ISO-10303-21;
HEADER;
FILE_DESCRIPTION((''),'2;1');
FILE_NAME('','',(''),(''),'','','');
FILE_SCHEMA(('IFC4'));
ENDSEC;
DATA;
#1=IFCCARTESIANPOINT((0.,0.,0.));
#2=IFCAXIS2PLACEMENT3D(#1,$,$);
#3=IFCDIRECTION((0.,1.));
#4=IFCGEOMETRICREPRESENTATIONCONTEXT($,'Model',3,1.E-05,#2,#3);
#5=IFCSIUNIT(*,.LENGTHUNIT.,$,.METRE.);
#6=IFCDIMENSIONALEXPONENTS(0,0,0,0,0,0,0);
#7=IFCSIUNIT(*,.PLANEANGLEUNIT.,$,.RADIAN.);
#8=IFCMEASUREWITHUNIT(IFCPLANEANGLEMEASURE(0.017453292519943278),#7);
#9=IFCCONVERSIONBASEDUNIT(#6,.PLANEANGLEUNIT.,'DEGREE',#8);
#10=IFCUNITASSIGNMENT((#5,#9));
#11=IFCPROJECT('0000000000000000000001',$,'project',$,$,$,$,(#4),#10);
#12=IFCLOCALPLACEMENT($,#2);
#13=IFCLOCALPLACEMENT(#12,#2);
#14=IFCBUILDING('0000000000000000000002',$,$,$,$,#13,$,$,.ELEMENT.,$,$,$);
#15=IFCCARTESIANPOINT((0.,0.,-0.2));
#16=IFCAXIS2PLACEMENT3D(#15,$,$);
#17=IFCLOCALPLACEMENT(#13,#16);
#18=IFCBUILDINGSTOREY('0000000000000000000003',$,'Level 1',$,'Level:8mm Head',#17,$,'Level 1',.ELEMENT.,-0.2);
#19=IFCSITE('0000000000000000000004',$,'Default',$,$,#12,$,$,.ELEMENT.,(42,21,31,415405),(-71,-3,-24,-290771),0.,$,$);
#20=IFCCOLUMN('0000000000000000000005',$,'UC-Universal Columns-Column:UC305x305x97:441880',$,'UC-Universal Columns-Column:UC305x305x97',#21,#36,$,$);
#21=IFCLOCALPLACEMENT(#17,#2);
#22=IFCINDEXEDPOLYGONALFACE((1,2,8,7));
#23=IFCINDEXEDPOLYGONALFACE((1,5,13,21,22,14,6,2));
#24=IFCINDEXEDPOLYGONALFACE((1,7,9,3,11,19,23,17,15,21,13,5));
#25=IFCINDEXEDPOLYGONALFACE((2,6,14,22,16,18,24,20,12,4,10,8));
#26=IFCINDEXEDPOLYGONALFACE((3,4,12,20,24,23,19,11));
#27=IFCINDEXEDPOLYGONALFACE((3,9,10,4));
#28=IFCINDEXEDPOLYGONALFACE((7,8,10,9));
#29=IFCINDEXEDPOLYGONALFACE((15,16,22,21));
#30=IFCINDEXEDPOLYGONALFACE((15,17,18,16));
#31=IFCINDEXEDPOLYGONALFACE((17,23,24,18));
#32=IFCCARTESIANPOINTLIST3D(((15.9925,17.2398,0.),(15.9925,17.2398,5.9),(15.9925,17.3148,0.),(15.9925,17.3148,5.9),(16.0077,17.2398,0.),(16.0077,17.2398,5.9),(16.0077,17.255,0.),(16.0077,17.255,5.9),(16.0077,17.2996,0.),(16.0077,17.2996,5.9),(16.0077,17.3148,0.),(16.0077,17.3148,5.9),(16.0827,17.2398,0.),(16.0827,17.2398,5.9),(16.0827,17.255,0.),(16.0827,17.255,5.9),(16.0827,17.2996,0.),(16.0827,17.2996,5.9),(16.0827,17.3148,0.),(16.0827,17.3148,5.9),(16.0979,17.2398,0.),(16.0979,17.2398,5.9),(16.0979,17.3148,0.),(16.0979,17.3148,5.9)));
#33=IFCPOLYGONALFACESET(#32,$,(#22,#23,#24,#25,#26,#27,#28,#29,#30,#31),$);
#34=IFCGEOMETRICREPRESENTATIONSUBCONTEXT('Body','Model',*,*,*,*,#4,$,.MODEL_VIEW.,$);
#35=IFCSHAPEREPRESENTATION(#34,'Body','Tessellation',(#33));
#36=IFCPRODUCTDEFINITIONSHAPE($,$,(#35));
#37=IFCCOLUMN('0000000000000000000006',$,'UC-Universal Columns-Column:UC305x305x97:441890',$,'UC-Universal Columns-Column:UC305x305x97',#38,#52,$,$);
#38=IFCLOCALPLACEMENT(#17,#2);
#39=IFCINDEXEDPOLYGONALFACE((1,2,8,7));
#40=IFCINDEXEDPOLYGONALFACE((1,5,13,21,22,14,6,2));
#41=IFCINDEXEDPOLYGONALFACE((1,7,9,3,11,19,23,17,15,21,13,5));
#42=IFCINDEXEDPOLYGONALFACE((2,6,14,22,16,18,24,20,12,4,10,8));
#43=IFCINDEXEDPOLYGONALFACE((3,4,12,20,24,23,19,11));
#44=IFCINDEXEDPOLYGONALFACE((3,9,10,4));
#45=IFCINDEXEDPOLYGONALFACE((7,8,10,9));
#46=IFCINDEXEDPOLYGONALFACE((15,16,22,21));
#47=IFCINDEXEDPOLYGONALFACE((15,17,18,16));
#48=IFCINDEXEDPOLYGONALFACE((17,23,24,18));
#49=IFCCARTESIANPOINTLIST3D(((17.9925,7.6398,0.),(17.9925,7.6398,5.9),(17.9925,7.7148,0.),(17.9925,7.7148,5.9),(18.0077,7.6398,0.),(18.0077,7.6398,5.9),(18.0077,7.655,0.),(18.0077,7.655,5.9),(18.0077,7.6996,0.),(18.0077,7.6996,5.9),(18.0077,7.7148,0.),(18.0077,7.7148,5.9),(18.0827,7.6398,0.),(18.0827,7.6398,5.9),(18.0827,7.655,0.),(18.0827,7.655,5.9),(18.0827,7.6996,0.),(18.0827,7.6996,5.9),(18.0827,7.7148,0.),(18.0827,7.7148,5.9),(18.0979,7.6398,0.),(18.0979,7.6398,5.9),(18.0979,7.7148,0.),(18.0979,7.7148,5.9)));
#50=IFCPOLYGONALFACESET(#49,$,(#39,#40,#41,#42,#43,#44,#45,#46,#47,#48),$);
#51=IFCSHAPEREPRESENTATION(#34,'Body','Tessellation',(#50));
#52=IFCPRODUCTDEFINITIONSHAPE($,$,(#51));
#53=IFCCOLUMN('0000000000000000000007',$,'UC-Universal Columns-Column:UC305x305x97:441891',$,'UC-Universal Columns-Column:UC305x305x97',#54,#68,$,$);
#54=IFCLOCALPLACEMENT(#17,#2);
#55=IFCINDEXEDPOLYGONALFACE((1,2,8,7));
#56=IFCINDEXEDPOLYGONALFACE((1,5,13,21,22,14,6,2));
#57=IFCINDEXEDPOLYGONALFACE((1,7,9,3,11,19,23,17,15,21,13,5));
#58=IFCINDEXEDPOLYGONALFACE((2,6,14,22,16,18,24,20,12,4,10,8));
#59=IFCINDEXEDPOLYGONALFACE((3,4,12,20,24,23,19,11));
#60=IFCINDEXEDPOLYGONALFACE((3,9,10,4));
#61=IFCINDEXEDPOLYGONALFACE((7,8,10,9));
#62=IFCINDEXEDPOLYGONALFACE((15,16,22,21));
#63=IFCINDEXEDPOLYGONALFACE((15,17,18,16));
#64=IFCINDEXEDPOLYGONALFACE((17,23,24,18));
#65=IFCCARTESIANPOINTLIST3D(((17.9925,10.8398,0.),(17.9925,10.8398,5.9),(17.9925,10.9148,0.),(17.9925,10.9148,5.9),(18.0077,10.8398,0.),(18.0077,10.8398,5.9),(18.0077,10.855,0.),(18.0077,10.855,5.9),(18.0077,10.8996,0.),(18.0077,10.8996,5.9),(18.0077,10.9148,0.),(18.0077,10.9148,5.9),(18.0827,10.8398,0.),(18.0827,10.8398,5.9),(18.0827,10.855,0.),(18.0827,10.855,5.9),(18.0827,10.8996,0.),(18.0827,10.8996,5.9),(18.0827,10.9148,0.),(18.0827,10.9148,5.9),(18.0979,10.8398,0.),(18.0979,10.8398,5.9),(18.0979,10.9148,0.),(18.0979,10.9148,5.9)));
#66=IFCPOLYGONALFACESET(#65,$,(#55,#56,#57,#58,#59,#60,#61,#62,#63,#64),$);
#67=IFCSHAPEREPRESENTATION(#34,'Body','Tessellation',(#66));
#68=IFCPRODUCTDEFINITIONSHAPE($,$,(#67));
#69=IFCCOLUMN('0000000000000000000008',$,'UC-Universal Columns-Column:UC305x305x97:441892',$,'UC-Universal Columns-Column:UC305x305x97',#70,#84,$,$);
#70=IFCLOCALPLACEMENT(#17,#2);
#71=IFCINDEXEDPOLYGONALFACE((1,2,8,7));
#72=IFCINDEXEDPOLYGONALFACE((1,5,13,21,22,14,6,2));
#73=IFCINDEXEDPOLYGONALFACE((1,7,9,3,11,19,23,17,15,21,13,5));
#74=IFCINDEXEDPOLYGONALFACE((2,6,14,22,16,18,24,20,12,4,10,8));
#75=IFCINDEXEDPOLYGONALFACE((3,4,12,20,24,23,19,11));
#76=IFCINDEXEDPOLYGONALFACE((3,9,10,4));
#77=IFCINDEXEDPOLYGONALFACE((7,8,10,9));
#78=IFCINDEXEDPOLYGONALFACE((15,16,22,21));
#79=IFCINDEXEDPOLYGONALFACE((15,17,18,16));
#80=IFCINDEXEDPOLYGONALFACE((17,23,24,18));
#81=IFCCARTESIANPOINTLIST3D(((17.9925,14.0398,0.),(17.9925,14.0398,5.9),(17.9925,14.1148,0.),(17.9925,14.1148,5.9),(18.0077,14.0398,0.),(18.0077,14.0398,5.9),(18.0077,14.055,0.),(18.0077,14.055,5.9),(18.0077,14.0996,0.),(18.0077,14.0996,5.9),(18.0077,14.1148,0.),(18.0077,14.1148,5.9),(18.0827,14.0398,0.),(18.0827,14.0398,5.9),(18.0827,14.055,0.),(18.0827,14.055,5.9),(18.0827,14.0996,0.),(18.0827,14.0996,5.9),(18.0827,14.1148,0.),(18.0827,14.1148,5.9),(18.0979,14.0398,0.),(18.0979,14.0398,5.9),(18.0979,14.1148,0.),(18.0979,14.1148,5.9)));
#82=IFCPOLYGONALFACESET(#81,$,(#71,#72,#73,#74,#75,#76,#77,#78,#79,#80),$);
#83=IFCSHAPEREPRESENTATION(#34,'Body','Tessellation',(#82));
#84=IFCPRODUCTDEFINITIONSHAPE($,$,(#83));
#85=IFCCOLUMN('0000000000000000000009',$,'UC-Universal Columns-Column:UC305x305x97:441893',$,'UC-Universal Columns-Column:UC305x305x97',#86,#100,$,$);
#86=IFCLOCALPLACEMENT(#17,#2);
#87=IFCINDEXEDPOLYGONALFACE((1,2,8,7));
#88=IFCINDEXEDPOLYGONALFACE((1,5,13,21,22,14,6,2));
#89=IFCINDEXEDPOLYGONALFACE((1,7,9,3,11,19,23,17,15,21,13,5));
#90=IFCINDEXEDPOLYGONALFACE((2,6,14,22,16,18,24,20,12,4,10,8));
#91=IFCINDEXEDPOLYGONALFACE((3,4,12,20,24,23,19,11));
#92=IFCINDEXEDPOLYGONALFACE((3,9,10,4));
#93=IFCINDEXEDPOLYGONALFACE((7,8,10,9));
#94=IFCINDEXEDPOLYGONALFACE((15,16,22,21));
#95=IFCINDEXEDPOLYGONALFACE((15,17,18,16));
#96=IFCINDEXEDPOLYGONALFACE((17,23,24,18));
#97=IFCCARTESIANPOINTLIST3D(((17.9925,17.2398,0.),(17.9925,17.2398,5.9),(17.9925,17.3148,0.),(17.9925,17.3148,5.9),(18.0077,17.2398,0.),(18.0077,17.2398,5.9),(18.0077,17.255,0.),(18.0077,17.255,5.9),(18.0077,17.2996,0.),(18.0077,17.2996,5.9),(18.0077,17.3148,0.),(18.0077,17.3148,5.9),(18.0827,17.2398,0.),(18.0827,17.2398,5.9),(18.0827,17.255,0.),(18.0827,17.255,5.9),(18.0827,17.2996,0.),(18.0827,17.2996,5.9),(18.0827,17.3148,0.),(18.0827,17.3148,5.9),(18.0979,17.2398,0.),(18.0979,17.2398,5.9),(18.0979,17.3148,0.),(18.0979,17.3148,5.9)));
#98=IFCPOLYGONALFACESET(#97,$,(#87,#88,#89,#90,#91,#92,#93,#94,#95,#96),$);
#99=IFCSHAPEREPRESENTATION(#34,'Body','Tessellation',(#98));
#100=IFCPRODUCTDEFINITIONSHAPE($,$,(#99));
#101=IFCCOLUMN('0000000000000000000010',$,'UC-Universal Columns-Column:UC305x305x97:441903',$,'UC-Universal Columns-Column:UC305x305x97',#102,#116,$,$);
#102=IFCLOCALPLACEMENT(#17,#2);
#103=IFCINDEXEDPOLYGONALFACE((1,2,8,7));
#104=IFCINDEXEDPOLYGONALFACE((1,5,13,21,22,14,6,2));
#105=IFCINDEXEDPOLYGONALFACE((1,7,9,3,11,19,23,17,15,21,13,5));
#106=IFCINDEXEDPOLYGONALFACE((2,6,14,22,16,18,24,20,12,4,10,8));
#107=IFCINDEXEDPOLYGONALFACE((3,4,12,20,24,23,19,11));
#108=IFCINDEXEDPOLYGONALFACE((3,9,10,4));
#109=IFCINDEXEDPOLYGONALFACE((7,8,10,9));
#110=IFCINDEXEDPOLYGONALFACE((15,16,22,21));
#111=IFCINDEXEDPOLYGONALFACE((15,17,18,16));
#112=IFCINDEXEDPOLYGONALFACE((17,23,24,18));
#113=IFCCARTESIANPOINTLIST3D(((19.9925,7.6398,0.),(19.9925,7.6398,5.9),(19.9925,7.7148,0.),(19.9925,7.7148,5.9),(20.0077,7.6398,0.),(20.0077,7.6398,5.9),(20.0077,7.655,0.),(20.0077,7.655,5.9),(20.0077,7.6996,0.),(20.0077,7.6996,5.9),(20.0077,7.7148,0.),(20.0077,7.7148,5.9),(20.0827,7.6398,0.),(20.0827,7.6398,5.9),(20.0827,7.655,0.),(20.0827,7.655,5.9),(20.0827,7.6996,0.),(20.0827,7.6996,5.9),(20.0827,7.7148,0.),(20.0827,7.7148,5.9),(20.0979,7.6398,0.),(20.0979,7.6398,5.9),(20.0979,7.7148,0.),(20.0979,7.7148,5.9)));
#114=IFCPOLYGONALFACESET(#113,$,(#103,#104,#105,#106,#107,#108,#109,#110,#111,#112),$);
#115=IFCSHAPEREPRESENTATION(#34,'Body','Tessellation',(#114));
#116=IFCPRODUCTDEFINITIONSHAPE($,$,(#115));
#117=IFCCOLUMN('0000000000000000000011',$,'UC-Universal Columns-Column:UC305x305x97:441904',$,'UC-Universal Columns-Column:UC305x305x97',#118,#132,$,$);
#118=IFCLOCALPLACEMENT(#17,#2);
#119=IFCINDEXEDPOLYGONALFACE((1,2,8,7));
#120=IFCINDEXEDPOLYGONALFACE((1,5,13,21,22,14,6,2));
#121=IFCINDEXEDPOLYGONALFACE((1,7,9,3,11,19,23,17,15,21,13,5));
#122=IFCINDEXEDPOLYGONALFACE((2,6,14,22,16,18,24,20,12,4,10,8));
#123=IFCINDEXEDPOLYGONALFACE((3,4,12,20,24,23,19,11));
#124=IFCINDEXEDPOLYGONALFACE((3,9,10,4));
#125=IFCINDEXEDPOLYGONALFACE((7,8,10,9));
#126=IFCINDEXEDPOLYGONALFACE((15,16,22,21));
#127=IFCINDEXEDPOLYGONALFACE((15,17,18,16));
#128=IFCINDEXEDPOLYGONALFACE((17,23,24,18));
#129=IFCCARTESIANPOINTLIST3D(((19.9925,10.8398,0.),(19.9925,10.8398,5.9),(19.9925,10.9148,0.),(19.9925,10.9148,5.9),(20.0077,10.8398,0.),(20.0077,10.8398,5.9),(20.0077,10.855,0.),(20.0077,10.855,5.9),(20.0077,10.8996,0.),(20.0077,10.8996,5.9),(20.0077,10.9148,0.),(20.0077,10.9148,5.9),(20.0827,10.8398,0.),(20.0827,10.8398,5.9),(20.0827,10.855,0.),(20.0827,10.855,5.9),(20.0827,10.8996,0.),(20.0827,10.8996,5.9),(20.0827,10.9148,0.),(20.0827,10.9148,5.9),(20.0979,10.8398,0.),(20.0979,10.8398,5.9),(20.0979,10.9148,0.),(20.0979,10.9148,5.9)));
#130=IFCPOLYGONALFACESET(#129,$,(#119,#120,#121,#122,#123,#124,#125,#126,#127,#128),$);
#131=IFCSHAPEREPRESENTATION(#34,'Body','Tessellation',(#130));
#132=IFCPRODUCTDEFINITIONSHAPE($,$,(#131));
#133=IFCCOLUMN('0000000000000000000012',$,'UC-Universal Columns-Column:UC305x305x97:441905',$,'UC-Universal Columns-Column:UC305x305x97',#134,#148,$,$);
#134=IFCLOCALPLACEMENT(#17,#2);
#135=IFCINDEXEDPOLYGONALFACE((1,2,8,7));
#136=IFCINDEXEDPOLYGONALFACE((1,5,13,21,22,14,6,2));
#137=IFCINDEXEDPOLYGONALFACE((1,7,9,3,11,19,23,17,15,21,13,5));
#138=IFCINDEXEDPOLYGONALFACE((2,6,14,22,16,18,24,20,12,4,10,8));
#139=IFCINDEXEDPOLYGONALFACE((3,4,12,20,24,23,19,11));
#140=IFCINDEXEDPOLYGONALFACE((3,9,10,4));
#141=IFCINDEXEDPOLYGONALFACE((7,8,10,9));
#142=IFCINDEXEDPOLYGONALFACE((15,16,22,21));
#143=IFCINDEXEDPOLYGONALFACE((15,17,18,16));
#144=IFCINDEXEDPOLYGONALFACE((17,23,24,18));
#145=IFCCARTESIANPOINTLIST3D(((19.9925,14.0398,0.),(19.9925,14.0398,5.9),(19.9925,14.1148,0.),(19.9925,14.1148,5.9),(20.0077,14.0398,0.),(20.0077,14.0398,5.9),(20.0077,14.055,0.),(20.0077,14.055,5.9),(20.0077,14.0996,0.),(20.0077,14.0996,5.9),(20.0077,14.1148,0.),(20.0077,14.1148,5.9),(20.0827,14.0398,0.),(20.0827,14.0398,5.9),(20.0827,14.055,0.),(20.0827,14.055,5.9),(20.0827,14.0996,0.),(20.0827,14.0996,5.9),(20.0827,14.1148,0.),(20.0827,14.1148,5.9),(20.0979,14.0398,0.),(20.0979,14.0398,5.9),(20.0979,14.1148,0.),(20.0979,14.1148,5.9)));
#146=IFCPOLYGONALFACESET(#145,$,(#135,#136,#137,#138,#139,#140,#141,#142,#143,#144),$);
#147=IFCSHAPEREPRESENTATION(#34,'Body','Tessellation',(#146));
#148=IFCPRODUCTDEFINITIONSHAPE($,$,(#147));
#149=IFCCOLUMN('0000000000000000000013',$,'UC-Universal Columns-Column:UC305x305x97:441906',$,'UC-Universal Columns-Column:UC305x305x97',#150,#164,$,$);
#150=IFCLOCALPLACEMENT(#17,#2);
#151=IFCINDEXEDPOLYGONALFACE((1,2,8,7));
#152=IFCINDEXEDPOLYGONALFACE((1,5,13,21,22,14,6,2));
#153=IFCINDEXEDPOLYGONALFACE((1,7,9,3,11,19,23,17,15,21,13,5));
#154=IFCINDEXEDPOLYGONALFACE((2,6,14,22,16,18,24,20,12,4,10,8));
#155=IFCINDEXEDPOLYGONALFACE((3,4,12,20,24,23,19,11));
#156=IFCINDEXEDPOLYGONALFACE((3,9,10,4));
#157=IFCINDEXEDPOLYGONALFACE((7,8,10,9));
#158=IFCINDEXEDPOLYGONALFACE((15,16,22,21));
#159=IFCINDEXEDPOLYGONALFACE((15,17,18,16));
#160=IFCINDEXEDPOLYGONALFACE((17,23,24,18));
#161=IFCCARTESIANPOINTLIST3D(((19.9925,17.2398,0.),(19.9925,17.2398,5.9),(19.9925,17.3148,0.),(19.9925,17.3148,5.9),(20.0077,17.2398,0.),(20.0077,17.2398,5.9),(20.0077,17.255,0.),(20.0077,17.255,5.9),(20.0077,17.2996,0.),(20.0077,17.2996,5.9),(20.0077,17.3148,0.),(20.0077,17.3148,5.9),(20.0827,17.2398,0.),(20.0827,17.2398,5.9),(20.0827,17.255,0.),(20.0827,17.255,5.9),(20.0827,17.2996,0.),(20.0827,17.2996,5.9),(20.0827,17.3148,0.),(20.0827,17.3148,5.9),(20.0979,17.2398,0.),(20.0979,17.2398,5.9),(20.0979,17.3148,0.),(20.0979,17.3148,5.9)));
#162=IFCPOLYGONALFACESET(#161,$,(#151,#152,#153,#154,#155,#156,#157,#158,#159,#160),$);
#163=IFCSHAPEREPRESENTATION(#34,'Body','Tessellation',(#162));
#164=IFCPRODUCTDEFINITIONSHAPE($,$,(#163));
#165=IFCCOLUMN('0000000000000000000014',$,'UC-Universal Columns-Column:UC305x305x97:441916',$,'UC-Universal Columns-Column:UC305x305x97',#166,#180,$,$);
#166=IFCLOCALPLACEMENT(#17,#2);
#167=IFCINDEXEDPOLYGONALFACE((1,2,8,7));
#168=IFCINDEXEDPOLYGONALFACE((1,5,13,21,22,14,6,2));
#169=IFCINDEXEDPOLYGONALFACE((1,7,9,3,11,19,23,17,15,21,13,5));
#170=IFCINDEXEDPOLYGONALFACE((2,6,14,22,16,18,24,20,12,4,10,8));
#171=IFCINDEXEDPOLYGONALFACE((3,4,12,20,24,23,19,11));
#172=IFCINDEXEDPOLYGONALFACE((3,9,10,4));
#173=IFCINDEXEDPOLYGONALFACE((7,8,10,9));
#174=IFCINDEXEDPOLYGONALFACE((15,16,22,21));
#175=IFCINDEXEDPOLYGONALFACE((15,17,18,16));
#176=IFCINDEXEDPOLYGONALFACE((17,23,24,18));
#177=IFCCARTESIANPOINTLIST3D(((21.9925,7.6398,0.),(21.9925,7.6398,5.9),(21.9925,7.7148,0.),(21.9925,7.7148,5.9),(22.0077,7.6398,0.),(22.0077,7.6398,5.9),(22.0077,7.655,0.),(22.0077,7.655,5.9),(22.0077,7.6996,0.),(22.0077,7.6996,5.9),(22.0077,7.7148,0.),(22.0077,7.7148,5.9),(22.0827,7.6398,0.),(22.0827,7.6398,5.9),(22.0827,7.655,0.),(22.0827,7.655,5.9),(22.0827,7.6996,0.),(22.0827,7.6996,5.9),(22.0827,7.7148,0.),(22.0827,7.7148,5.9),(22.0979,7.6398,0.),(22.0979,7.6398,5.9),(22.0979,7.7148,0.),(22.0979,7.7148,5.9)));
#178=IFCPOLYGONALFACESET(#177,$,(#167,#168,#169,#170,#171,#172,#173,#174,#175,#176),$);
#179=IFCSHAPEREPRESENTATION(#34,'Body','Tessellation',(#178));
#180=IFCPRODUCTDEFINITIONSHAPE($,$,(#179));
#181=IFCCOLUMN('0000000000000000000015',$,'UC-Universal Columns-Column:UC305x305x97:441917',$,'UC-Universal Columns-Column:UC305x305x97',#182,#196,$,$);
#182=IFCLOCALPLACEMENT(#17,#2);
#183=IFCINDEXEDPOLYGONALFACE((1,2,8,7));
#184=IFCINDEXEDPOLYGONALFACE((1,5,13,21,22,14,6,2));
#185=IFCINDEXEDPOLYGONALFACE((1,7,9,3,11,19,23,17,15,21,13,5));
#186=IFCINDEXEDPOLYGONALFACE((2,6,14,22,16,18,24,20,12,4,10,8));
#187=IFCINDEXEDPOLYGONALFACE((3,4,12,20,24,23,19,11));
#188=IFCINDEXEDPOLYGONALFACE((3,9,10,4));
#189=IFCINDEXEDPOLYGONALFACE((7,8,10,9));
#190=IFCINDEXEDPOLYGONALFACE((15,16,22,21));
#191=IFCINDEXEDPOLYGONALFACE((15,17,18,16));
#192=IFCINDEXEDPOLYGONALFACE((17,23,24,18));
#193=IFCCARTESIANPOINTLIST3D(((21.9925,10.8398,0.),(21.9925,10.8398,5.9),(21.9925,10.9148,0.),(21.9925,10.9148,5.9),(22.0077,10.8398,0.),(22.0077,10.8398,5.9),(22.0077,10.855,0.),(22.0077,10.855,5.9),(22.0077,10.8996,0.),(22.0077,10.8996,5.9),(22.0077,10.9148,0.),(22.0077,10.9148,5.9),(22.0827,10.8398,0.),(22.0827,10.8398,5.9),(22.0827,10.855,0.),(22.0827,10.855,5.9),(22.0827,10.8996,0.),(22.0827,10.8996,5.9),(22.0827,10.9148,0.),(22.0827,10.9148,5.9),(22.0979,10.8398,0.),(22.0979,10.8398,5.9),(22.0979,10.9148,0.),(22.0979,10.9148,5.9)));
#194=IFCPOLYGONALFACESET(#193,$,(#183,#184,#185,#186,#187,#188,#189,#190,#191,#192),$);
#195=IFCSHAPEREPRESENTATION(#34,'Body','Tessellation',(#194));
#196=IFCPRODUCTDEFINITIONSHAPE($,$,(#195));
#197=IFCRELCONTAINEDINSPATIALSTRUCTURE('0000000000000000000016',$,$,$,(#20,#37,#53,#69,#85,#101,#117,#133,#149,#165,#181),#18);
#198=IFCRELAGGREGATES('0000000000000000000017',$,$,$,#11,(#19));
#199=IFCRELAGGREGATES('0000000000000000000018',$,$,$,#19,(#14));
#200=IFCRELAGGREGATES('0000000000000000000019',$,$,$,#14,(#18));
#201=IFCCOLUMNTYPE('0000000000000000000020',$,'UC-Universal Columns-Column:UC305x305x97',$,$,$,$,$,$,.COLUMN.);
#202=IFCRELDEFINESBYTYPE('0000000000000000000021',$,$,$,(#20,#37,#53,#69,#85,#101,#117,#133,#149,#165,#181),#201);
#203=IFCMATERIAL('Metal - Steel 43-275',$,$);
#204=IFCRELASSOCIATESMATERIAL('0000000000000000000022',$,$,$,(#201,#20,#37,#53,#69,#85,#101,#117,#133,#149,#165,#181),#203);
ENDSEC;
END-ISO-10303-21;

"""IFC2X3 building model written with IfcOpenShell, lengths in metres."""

from ifc_helpers import new_model, entity, si_unit, converted_unit, direction, frame, frame_2d, origin, place, context, subcontext, project, spatial, polyline, circle_curve, parameter, trimmed, segment, composite_curve, outline, extrude, source, transform, mapped, material, type_object, type_shapes, element, save


model = new_model("IFC2X3")

# Units and contexts
model_context = context("Model", 3, precision=1e-05, world=origin(), true_north=direction((0.0, 1.0)))
body_context = subcontext(model_context, "Body", "Model", "MODEL_VIEW")
ifc_project = project(units=[si_unit("LENGTHUNIT", "METRE"), converted_unit("PLANEANGLEUNIT", "DEGREE", entity("IfcPlaneAngleMeasure", 0.017453292519943278), si_unit("PLANEANGLEUNIT", "RADIAN"), dimensions=[0, 0, 0, 0, 0, 0, 0])], contexts=[model_context])

# Site, building, storey
site_placement = place(None, origin())
site = spatial("IfcSite", under=ifc_project, at=site_placement, Name="Default", CompositionType="ELEMENT", RefLatitude=(42, 21, 31, 415405), RefLongitude=(-71, -3, -24, -290771), RefElevation=0.0)
building_placement = place(site_placement, origin())
building = spatial("IfcBuilding", under=site, at=building_placement, CompositionType="ELEMENT")
storey_placement = place(building_placement, frame((0.0, 0.0, -0.2)))
storey = spatial("IfcBuildingStorey", under=building, at=storey_placement, Name="Level 1", ObjectType="Level:8mm Head", LongName="Level 1", CompositionType="ELEMENT", Elevation=-0.2)

# Columns
ifc_material = material(Name="Metal - Steel 43-275")
column_type = type_object("IfcColumnType", Name="UC-Universal Columns-Column:UC305x305x97", PredefinedType="COLUMN", material=ifc_material)
shared_shape = source(origin(), body_context, "Body", "SweptSolid", [
    extrude(outline(composite_curve([segment(polyline([(-0.0375, -0.0375), (0.0375, -0.0375)]), True, "CONTINUOUS"), segment(polyline([(0.0375, -0.0375), (0.0527, -0.0375)]), True, "CONTINUOUS"), segment(trimmed(circle_curve(frame_2d((0.0527, -0.0223), x_axis=(-1.0, 0.0)), 0.0152), [parameter(0.0)], [parameter(90.0)], True, "PARAMETER"), False, "CONTINUOUS"), segment(polyline([(0.0375, -0.0223), (0.0375, 0.0223)]), True, "CONTINUOUS"), segment(trimmed(circle_curve(frame_2d((0.0527, 0.0223), x_axis=(-1.0, 0.0)), 0.0152), [parameter(270.0)], [parameter(0.0)], True, "PARAMETER"), False, "CONTINUOUS"), segment(polyline([(0.0527, 0.0375), (0.0375, 0.0375)]), True, "CONTINUOUS"), segment(polyline([(0.0375, 0.0375), (-0.0375, 0.0375)]), True, "CONTINUOUS"), segment(polyline([(-0.0375, 0.0375), (-0.0527, 0.0375)]), True, "CONTINUOUS"), segment(trimmed(circle_curve(frame_2d((-0.0527, 0.0223), x_axis=(-1.0, 0.0)), 0.0152), [parameter(180.0)], [parameter(270.0)], True, "PARAMETER"), False, "CONTINUOUS"), segment(polyline([(-0.0375, 0.0223), (-0.0375, -0.0223)]), True, "CONTINUOUS"), segment(trimmed(circle_curve(frame_2d((-0.0527, -0.0223), x_axis=(-1.0, 0.0)), 0.0152), [parameter(90.0)], [parameter(180.0)], True, "PARAMETER"), False, "CONTINUOUS"), segment(polyline([(-0.0527, -0.0375), (-0.0375, -0.0375)]), True, "CONTINUOUS")], self_intersect=False)), frame((0.0, 0.0, -0.2), z_axis=(0.0, 0.0, 1.0), x_axis=(-1.0, 0.0, 0.0)), (0.0, 0.0, 1.0), 5.9),
])
type_shapes(column_type, [shared_shape])
for number, where, z_axis, x_axis, name in (
    (1, (16.0452, 17.2773, 0.2), (0.0, 0.0, 1.0), (-1.0, 0.0, 0.0), "UC-Universal Columns-Column:UC305x305x97:441880"),
    (2, (18.0452, 7.6773, 0.2), (0.0, 0.0, 1.0), (-1.0, 0.0, 0.0), "UC-Universal Columns-Column:UC305x305x97:441890"),
    (3, (18.0452, 10.8773, 0.2), (0.0, 0.0, 1.0), (-1.0, 0.0, 0.0), "UC-Universal Columns-Column:UC305x305x97:441891"),
    (4, (18.0452, 14.0773, 0.2), (0.0, 0.0, 1.0), (-1.0, 0.0, 0.0), "UC-Universal Columns-Column:UC305x305x97:441892"),
    (5, (18.0452, 17.2773, 0.2), (0.0, 0.0, 1.0), (-1.0, 0.0, 0.0), "UC-Universal Columns-Column:UC305x305x97:441893"),
    (6, (20.0452, 7.6773, 0.2), (0.0, 0.0, 1.0), (-1.0, 0.0, 0.0), "UC-Universal Columns-Column:UC305x305x97:441903"),
    (7, (20.0452, 10.8773, 0.2), (0.0, 0.0, 1.0), (-1.0, 0.0, 0.0), "UC-Universal Columns-Column:UC305x305x97:441904"),
    (8, (20.0452, 14.0773, 0.2), (0.0, 0.0, 1.0), (-1.0, 0.0, 0.0), "UC-Universal Columns-Column:UC305x305x97:441905"),
    (9, (20.0452, 17.2773, 0.2), (0.0, 0.0, 1.0), (-1.0, 0.0, 0.0), "UC-Universal Columns-Column:UC305x305x97:441906"),
    (10, (22.0452, 7.6773, 0.2), (0.0, 0.0, 1.0), (-1.0, 0.0, 0.0), "UC-Universal Columns-Column:UC305x305x97:441916"),
    (11, (22.0452, 10.8773, 0.2), (0.0, 0.0, 1.0), (-1.0, 0.0, 0.0), "UC-Universal Columns-Column:UC305x305x97:441917"),
):
    element("IfcColumn", number, at=place(storey_placement, frame(where, z_axis=z_axis, x_axis=x_axis)), inside=storey, type_object=column_type, material=ifc_material, Name=name, ObjectType="UC-Universal Columns-Column:UC305x305x97", context=body_context, shape_type="MappedRepresentation", body=[
        mapped(shared_shape, transform((0.0, 0.0, 0.0), scale=1.0)),
    ])

save(model, "model.ifc")
